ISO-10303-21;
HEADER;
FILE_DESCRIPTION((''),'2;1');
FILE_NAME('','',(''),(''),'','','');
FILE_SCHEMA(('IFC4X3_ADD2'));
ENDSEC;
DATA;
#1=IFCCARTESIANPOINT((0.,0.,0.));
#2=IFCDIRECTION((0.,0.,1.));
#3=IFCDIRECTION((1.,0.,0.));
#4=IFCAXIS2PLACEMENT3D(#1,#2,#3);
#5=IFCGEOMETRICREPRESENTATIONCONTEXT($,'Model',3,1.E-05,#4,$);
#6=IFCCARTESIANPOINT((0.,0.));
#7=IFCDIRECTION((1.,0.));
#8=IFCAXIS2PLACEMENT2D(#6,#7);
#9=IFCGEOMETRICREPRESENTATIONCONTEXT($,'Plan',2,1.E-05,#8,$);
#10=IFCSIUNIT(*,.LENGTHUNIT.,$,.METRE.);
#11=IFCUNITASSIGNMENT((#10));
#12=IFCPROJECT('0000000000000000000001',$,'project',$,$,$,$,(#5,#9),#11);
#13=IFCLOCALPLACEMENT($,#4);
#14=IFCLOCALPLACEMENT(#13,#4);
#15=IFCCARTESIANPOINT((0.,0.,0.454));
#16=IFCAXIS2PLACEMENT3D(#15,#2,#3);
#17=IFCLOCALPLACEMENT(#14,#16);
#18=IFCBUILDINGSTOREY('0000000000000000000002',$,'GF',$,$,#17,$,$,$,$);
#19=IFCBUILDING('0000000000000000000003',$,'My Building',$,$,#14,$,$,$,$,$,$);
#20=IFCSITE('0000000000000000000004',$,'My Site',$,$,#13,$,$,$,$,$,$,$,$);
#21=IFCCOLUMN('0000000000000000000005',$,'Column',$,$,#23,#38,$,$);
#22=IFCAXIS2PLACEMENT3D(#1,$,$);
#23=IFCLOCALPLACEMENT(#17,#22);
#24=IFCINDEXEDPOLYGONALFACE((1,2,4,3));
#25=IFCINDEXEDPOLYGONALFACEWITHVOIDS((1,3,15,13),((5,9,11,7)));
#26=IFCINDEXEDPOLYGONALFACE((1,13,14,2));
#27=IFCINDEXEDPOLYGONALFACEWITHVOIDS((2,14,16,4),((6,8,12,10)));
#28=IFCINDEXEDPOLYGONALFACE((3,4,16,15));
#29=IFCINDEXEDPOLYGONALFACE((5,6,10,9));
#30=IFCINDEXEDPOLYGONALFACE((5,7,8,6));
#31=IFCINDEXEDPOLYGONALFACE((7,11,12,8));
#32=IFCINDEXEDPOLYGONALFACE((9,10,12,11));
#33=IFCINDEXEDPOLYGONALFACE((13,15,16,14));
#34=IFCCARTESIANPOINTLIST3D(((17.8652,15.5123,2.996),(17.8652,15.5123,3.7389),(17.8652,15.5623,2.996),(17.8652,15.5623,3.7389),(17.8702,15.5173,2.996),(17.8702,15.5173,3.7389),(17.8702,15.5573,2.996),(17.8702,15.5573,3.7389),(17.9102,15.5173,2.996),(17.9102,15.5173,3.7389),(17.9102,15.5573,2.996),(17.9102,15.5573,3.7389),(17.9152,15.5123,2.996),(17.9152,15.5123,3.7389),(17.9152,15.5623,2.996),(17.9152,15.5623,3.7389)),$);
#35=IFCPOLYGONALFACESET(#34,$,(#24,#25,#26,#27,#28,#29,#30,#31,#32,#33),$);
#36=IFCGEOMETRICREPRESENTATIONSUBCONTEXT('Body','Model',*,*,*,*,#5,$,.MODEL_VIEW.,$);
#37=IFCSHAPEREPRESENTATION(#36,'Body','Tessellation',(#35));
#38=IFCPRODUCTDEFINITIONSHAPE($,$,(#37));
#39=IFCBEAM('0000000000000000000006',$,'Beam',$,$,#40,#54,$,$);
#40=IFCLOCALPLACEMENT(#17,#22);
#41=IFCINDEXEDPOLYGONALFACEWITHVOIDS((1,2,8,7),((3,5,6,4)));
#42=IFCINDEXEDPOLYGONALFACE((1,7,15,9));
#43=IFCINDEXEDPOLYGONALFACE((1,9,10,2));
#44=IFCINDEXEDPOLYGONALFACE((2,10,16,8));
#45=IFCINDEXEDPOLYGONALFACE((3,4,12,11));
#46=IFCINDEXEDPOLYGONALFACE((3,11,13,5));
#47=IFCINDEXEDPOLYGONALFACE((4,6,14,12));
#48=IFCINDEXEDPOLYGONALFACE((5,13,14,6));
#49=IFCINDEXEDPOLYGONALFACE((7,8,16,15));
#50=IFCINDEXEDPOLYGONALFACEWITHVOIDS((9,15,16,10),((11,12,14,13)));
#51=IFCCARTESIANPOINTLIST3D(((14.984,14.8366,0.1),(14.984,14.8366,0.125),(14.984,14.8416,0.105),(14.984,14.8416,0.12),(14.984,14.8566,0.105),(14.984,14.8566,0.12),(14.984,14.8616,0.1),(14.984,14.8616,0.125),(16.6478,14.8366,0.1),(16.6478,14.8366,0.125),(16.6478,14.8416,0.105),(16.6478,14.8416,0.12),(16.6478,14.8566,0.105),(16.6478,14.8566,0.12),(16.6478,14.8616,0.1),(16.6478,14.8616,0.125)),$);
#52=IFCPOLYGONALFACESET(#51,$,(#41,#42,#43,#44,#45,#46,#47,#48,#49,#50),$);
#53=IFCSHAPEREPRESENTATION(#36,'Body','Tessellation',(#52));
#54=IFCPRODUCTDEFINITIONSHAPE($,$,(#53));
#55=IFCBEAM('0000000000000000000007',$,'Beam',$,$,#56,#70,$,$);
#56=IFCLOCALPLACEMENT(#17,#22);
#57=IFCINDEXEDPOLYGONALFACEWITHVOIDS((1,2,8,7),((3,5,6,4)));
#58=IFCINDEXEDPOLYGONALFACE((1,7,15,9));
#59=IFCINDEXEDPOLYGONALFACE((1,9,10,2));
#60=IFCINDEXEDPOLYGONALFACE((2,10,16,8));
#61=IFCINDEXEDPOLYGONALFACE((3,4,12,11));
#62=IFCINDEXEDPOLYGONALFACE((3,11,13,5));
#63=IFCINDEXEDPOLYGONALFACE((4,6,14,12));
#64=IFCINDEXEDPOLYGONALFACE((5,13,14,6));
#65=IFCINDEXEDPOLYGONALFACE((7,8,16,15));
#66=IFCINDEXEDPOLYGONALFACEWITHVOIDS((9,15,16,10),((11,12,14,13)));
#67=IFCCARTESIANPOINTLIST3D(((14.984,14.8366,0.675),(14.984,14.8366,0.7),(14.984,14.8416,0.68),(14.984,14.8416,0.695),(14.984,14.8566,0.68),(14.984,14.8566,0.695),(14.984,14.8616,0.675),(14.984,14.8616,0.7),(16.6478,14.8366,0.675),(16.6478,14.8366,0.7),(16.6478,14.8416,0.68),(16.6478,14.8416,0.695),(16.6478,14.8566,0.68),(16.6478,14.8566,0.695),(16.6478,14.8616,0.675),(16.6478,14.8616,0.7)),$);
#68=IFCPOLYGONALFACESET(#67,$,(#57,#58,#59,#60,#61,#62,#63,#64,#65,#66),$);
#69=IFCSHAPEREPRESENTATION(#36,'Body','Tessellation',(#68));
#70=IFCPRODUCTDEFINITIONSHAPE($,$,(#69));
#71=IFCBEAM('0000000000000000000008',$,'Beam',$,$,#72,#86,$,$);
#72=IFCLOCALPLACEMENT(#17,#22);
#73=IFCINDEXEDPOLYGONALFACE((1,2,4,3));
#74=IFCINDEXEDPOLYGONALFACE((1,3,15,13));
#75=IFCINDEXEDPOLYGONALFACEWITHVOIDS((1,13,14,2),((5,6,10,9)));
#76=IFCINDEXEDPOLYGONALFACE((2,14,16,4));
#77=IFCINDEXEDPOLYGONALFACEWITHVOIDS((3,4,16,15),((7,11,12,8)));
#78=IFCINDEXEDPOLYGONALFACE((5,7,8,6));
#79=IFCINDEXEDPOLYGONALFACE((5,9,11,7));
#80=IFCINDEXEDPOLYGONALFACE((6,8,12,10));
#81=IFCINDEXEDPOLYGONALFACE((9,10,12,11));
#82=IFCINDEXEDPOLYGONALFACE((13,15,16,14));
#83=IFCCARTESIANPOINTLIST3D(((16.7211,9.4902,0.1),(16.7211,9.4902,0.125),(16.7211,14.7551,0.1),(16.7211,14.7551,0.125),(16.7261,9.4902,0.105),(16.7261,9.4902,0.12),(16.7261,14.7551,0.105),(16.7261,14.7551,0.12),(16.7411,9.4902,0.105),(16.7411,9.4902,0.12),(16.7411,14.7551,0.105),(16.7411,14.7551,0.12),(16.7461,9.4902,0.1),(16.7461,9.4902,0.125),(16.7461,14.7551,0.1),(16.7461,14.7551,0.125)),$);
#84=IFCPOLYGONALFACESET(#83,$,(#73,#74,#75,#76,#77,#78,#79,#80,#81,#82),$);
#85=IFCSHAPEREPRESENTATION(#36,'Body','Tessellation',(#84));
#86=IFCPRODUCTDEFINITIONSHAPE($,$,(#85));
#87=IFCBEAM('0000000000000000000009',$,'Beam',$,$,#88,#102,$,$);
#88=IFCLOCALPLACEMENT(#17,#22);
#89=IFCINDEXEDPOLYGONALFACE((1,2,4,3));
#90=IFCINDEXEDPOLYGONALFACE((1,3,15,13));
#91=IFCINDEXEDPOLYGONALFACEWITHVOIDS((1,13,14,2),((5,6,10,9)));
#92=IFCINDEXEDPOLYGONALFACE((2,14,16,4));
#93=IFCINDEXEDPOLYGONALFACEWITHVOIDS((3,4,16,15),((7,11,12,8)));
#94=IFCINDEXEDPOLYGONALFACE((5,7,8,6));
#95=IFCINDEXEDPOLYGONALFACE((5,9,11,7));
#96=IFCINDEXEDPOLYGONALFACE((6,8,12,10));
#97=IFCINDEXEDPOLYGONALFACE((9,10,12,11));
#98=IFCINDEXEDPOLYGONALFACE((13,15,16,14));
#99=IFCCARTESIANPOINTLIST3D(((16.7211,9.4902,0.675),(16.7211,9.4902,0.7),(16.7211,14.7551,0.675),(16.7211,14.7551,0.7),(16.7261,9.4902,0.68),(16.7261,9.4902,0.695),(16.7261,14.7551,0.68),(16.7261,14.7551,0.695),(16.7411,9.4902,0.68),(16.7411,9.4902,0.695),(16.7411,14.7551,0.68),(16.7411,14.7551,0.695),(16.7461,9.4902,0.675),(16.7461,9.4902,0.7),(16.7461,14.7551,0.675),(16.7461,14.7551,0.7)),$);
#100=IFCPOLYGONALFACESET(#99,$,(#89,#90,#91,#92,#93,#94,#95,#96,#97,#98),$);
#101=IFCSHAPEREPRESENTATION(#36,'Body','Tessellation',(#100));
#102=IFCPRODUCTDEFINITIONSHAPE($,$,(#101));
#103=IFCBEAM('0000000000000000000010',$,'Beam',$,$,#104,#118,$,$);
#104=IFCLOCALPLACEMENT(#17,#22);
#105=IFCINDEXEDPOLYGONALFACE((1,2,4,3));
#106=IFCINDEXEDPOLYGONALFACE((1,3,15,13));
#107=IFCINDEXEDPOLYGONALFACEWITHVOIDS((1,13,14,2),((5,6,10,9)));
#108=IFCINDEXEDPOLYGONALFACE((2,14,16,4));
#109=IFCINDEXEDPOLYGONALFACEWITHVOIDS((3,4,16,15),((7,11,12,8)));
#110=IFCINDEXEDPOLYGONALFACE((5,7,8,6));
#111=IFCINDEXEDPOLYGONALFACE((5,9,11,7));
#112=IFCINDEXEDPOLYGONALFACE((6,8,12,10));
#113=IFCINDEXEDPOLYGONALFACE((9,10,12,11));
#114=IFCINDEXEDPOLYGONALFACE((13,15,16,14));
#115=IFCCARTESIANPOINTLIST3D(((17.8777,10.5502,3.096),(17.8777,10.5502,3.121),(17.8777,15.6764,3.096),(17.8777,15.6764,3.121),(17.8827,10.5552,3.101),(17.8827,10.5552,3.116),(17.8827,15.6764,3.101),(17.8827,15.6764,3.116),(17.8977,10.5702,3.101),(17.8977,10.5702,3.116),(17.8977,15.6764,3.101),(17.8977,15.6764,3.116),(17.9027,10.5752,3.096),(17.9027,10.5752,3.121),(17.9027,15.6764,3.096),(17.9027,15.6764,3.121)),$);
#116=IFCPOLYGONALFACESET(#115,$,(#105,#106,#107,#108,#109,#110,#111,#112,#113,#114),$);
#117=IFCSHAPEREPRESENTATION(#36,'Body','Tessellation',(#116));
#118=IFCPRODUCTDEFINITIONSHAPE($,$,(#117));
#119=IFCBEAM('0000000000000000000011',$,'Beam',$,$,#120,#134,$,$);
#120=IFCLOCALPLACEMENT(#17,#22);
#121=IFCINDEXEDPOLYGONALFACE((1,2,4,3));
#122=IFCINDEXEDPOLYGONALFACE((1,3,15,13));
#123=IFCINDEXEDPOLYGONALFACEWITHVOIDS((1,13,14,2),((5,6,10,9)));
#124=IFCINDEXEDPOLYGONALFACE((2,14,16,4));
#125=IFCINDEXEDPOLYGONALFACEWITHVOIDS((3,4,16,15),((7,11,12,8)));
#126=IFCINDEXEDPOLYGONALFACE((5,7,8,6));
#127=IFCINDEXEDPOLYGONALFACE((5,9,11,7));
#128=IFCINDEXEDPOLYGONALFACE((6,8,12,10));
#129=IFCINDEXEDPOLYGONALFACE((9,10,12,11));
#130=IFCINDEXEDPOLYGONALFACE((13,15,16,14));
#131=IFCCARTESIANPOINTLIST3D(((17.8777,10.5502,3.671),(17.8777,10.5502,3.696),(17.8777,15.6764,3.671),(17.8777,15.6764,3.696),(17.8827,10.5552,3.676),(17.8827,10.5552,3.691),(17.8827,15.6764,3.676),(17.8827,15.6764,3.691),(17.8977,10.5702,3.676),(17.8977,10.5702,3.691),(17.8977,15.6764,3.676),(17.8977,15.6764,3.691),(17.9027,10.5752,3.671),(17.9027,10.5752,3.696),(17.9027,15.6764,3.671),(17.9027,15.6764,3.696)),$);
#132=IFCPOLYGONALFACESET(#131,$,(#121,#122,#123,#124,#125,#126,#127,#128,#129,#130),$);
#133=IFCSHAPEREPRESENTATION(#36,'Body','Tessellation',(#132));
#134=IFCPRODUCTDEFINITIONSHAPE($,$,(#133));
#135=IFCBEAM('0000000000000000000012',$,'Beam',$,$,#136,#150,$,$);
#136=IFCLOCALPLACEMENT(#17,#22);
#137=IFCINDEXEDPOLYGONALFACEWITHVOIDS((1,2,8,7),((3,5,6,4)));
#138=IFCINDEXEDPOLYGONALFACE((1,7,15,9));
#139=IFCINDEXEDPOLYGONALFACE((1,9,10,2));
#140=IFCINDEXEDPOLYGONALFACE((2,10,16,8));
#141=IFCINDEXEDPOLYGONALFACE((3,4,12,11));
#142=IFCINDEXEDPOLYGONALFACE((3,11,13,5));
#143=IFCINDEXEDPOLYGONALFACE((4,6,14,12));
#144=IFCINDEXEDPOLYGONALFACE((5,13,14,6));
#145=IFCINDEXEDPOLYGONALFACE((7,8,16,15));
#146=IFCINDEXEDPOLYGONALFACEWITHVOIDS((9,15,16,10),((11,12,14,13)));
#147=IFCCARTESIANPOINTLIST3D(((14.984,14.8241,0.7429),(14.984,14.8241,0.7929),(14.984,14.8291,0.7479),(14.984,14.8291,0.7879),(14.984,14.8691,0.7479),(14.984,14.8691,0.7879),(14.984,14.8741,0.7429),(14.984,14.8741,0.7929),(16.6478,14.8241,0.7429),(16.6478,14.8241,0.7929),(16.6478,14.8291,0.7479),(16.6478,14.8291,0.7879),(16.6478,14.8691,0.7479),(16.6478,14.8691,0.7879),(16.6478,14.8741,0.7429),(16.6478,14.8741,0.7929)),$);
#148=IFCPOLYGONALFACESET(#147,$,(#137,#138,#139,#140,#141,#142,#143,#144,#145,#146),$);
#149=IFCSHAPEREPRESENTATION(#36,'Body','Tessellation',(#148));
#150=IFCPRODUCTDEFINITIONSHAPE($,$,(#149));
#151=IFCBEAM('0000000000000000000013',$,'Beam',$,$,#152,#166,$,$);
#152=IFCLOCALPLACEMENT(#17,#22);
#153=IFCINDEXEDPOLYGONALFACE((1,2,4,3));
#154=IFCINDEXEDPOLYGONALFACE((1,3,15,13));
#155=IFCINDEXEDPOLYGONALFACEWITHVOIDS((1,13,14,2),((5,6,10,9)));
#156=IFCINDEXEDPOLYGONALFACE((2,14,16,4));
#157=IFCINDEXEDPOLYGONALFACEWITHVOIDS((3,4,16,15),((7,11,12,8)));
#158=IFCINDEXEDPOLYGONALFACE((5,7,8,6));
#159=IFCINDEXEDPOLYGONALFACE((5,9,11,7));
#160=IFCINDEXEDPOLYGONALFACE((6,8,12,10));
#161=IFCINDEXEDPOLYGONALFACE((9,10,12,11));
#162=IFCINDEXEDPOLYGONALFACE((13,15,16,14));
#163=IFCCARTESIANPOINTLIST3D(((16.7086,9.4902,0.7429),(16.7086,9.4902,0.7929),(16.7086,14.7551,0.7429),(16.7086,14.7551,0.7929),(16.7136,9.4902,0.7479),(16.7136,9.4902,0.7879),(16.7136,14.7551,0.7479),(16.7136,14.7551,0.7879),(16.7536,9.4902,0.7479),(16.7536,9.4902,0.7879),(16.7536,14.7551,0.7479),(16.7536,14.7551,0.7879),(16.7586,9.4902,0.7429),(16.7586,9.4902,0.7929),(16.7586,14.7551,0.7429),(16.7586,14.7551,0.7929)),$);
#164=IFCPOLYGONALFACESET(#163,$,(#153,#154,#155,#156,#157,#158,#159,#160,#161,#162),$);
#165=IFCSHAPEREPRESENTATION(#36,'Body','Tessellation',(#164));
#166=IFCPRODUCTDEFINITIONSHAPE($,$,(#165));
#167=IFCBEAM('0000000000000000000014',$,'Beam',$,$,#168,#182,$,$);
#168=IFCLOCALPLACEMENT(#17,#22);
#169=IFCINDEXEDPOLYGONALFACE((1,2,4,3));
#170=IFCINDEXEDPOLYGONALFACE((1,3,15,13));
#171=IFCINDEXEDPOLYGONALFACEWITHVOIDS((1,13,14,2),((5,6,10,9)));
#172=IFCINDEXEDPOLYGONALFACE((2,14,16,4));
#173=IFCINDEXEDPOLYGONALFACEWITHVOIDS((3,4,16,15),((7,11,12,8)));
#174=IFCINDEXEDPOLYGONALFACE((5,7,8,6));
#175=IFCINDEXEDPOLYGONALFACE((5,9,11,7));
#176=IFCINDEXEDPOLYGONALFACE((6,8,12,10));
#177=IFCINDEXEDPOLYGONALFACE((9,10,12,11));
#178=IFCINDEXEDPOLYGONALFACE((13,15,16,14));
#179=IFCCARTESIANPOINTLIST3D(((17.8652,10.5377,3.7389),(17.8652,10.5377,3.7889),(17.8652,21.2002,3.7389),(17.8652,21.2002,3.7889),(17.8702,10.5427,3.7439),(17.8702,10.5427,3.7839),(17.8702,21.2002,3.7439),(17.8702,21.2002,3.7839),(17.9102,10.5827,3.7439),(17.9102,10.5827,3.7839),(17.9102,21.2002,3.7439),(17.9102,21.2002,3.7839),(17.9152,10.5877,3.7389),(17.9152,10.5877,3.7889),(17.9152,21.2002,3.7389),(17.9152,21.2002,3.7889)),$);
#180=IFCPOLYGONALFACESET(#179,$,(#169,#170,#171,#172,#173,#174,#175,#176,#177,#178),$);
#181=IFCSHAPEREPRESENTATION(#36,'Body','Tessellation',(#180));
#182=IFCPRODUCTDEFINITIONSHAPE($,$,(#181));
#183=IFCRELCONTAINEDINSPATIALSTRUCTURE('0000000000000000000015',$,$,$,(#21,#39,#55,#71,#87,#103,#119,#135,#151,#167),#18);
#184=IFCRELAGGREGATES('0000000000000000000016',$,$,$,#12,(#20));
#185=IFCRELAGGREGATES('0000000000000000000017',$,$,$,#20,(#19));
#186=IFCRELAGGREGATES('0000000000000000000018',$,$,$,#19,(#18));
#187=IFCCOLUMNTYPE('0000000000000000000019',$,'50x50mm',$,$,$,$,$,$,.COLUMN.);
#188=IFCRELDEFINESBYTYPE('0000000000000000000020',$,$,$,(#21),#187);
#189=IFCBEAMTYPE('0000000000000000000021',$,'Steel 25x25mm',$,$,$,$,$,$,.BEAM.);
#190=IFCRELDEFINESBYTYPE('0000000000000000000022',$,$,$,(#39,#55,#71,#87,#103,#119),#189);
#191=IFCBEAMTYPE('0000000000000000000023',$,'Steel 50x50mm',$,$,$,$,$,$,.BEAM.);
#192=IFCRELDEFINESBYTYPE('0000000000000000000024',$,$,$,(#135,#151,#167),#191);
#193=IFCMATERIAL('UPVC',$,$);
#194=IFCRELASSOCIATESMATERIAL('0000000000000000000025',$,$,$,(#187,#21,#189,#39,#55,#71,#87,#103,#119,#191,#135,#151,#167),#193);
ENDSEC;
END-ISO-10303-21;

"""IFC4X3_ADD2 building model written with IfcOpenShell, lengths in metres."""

from ifc_helpers import new_model, si_unit, frame, origin_with_axes, origin_2d_with_axis, place, context, subcontext, project, spatial, hollow_rectangle, extrude, clip, halfspace, material, material_profile, profile_set, profile_usage, type_object, element, save


model = new_model("IFC4X3_ADD2")

# Units and contexts
model_context = context("Model", 3, precision=1e-05, world=origin_with_axes())
plan_context = context("Plan", 2, precision=1e-05, world=origin_2d_with_axis())
body_context = subcontext(model_context, "Body", "Model", "MODEL_VIEW")
ifc_project = project(units=[si_unit("LENGTHUNIT", "METRE")], contexts=[model_context, plan_context])

# Site, building, storey
site_placement = place(None, origin_with_axes())
site = spatial("IfcSite", under=ifc_project, at=site_placement, Name="My Site")
building_placement = place(site_placement, origin_with_axes())
building = spatial("IfcBuilding", under=site, at=building_placement, Name="My Building")
storey_placement = place(building_placement, frame((0.0, 0.0, 0.454), z_axis=(0.0, 0.0, 1.0), x_axis=(1.0, 0.0, 0.0)))
storey = spatial("IfcBuildingStorey", under=building, at=storey_placement, Name="GF")

# Column
ifc_material_1 = material(Name="UPVC")
ifc_material_profile_1 = material_profile(ifc_material_1, hollow_rectangle(XDim=0.05, YDim=0.05, WallThickness=0.005))
ifc_profile_set_1 = profile_set([ifc_material_profile_1])
column_type_1 = type_object("IfcColumnType", Name="50x50mm", PredefinedType="COLUMN", material=ifc_profile_set_1)
ifc_profile_usage_1 = profile_usage(ifc_profile_set_1)
column_1_placement = place(storey_placement, frame((17.8902, 15.5373, 2.996), z_axis=(0.0, 0.0, 1.0), x_axis=(0.0, -1.0, 0.0)))
element("IfcColumn", 1, at=column_1_placement, inside=storey, type_object=column_type_1, material=ifc_profile_usage_1, Name="Column", context=body_context, shape_type="SweptSolid", body=[
    extrude(hollow_rectangle(XDim=0.05, YDim=0.05, WallThickness=0.005), origin_with_axes(), (0.0, 0.0, 1.0), 0.7429),
])

# Beams
ifc_material_profile_2 = material_profile(ifc_material_1, hollow_rectangle(XDim=0.025, YDim=0.025, WallThickness=0.005))
ifc_profile_set_2 = profile_set([ifc_material_profile_2])
ifc_profile_usage_2 = profile_usage(ifc_profile_set_2)
beam_type_1 = type_object("IfcBeamType", Name="Steel 25x25mm", PredefinedType="BEAM", material=ifc_profile_set_2)
beam_1_placement = place(storey_placement, frame((14.984, 14.8491, 0.1125), z_axis=(1.0, 0.0, 0.0), x_axis=(0.0, 1.0, 0.0)))
element("IfcBeam", 2, at=beam_1_placement, inside=storey, type_object=beam_type_1, material=ifc_profile_usage_2, Name="Beam", context=body_context, shape_type="SweptSolid", body=[
    extrude(hollow_rectangle(XDim=0.025, YDim=0.025, WallThickness=0.005), origin_with_axes(), (0.0, 0.0, 1.0), 1.6638),
])
ifc_profile_usage_3 = profile_usage(ifc_profile_set_2)
beam_2_placement = place(storey_placement, frame((14.984, 14.8491, 0.6875), z_axis=(1.0, 0.0, 0.0), x_axis=(0.0, 1.0, 0.0)))
element("IfcBeam", 3, at=beam_2_placement, inside=storey, type_object=beam_type_1, material=ifc_profile_usage_3, Name="Beam", context=body_context, shape_type="SweptSolid", body=[
    extrude(hollow_rectangle(XDim=0.025, YDim=0.025, WallThickness=0.005), origin_with_axes(), (0.0, 0.0, 1.0), 1.6638),
])
ifc_profile_usage_4 = profile_usage(ifc_profile_set_2)
beam_3_placement = place(storey_placement, frame((16.7336, 14.7551, 0.1125), z_axis=(0.0, -1.0, 0.0), x_axis=(1.0, 0.0, 0.0)))
element("IfcBeam", 4, at=beam_3_placement, inside=storey, type_object=beam_type_1, material=ifc_profile_usage_4, Name="Beam", context=body_context, shape_type="SweptSolid", body=[
    extrude(hollow_rectangle(XDim=0.025, YDim=0.025, WallThickness=0.005), origin_with_axes(), (0.0, 0.0, 1.0), 5.2649),
])
ifc_profile_usage_5 = profile_usage(ifc_profile_set_2)
beam_4_placement = place(storey_placement, frame((16.7336, 14.7551, 0.6875), z_axis=(0.0, -1.0, 0.0), x_axis=(1.0, 0.0, 0.0)))
element("IfcBeam", 5, at=beam_4_placement, inside=storey, type_object=beam_type_1, material=ifc_profile_usage_5, Name="Beam", context=body_context, shape_type="SweptSolid", body=[
    extrude(hollow_rectangle(XDim=0.025, YDim=0.025, WallThickness=0.005), origin_with_axes(), (0.0, 0.0, 1.0), 5.2649),
])
ifc_profile_usage_6 = profile_usage(ifc_profile_set_2)
beam_5_placement = place(storey_placement, frame((17.8902, 15.6764, 3.1085), z_axis=(0.0, -1.0, 0.0), x_axis=(1.0, 0.0, 0.0)))
element("IfcBeam", 6, at=beam_5_placement, inside=storey, type_object=beam_type_1, material=ifc_profile_usage_6, Name="Beam", context=body_context, shape_type="Clipping", body=[
    clip(extrude(hollow_rectangle(XDim=0.025, YDim=0.025, WallThickness=0.005), origin_with_axes(), (0.0, 0.0, 1.0), 5.1262), halfspace(frame((-0.0125, -3.5625, 5.1262), z_axis=(0.70708, 0.0, 0.707134), x_axis=(0.0, -1.0, 0.0)), False)),
])
ifc_profile_usage_7 = profile_usage(ifc_profile_set_2)
beam_6_placement = place(storey_placement, frame((17.8902, 15.6764, 3.6835), z_axis=(0.0, -1.0, 0.0), x_axis=(1.0, 0.0, 0.0)))
element("IfcBeam", 7, at=beam_6_placement, inside=storey, type_object=beam_type_1, material=ifc_profile_usage_7, Name="Beam", context=body_context, shape_type="Clipping", body=[
    clip(extrude(hollow_rectangle(XDim=0.025, YDim=0.025, WallThickness=0.005), origin_with_axes(), (0.0, 0.0, 1.0), 5.1262), halfspace(frame((-0.0125, -4.1375, 5.1262), z_axis=(0.70708, 0.0, 0.707134), x_axis=(0.0, -1.0, 0.0)), False)),
])
ifc_material_profile_3 = material_profile(ifc_material_1, hollow_rectangle(XDim=0.05, YDim=0.05, WallThickness=0.005))
ifc_profile_set_3 = profile_set([ifc_material_profile_3])
ifc_profile_usage_8 = profile_usage(ifc_profile_set_3)
beam_type_2 = type_object("IfcBeamType", Name="Steel 50x50mm", PredefinedType="BEAM", material=ifc_profile_set_3)
beam_7_placement = place(storey_placement, frame((14.984, 14.8491, 0.7679), z_axis=(1.0, 0.0, 0.0), x_axis=(0.0, 1.0, 0.0)))
element("IfcBeam", 8, at=beam_7_placement, inside=storey, type_object=beam_type_2, material=ifc_profile_usage_8, Name="Beam", context=body_context, shape_type="SweptSolid", body=[
    extrude(hollow_rectangle(XDim=0.05, YDim=0.05, WallThickness=0.005), origin_with_axes(), (0.0, 0.0, 1.0), 1.6638),
])
ifc_profile_usage_9 = profile_usage(ifc_profile_set_3)
beam_8_placement = place(storey_placement, frame((16.7336, 14.7551, 0.7679), z_axis=(0.0, -1.0, 0.0), x_axis=(1.0, 0.0, 0.0)))
element("IfcBeam", 9, at=beam_8_placement, inside=storey, type_object=beam_type_2, material=ifc_profile_usage_9, Name="Beam", context=body_context, shape_type="SweptSolid", body=[
    extrude(hollow_rectangle(XDim=0.05, YDim=0.05, WallThickness=0.005), origin_with_axes(), (0.0, 0.0, 1.0), 5.2649),
])
ifc_profile_usage_10 = profile_usage(ifc_profile_set_3)
beam_9_placement = place(storey_placement, frame((17.8902, 21.2002, 3.7639), z_axis=(0.0, -1.0, 0.0), x_axis=(1.0, 0.0, 0.0)))
element("IfcBeam", 10, at=beam_9_placement, inside=storey, type_object=beam_type_2, material=ifc_profile_usage_10, Name="Beam", context=body_context, shape_type="Clipping", body=[
    clip(extrude(hollow_rectangle(XDim=0.05, YDim=0.05, WallThickness=0.005), origin_with_axes(), (0.0, 0.0, 1.0), 10.6625), halfspace(frame((-0.025, -4.2179, 10.6625), z_axis=(0.707107, 0.0, 0.707107), x_axis=(0.0, -1.0, 0.0)), False)),
])

save(model, "model.ifc")
